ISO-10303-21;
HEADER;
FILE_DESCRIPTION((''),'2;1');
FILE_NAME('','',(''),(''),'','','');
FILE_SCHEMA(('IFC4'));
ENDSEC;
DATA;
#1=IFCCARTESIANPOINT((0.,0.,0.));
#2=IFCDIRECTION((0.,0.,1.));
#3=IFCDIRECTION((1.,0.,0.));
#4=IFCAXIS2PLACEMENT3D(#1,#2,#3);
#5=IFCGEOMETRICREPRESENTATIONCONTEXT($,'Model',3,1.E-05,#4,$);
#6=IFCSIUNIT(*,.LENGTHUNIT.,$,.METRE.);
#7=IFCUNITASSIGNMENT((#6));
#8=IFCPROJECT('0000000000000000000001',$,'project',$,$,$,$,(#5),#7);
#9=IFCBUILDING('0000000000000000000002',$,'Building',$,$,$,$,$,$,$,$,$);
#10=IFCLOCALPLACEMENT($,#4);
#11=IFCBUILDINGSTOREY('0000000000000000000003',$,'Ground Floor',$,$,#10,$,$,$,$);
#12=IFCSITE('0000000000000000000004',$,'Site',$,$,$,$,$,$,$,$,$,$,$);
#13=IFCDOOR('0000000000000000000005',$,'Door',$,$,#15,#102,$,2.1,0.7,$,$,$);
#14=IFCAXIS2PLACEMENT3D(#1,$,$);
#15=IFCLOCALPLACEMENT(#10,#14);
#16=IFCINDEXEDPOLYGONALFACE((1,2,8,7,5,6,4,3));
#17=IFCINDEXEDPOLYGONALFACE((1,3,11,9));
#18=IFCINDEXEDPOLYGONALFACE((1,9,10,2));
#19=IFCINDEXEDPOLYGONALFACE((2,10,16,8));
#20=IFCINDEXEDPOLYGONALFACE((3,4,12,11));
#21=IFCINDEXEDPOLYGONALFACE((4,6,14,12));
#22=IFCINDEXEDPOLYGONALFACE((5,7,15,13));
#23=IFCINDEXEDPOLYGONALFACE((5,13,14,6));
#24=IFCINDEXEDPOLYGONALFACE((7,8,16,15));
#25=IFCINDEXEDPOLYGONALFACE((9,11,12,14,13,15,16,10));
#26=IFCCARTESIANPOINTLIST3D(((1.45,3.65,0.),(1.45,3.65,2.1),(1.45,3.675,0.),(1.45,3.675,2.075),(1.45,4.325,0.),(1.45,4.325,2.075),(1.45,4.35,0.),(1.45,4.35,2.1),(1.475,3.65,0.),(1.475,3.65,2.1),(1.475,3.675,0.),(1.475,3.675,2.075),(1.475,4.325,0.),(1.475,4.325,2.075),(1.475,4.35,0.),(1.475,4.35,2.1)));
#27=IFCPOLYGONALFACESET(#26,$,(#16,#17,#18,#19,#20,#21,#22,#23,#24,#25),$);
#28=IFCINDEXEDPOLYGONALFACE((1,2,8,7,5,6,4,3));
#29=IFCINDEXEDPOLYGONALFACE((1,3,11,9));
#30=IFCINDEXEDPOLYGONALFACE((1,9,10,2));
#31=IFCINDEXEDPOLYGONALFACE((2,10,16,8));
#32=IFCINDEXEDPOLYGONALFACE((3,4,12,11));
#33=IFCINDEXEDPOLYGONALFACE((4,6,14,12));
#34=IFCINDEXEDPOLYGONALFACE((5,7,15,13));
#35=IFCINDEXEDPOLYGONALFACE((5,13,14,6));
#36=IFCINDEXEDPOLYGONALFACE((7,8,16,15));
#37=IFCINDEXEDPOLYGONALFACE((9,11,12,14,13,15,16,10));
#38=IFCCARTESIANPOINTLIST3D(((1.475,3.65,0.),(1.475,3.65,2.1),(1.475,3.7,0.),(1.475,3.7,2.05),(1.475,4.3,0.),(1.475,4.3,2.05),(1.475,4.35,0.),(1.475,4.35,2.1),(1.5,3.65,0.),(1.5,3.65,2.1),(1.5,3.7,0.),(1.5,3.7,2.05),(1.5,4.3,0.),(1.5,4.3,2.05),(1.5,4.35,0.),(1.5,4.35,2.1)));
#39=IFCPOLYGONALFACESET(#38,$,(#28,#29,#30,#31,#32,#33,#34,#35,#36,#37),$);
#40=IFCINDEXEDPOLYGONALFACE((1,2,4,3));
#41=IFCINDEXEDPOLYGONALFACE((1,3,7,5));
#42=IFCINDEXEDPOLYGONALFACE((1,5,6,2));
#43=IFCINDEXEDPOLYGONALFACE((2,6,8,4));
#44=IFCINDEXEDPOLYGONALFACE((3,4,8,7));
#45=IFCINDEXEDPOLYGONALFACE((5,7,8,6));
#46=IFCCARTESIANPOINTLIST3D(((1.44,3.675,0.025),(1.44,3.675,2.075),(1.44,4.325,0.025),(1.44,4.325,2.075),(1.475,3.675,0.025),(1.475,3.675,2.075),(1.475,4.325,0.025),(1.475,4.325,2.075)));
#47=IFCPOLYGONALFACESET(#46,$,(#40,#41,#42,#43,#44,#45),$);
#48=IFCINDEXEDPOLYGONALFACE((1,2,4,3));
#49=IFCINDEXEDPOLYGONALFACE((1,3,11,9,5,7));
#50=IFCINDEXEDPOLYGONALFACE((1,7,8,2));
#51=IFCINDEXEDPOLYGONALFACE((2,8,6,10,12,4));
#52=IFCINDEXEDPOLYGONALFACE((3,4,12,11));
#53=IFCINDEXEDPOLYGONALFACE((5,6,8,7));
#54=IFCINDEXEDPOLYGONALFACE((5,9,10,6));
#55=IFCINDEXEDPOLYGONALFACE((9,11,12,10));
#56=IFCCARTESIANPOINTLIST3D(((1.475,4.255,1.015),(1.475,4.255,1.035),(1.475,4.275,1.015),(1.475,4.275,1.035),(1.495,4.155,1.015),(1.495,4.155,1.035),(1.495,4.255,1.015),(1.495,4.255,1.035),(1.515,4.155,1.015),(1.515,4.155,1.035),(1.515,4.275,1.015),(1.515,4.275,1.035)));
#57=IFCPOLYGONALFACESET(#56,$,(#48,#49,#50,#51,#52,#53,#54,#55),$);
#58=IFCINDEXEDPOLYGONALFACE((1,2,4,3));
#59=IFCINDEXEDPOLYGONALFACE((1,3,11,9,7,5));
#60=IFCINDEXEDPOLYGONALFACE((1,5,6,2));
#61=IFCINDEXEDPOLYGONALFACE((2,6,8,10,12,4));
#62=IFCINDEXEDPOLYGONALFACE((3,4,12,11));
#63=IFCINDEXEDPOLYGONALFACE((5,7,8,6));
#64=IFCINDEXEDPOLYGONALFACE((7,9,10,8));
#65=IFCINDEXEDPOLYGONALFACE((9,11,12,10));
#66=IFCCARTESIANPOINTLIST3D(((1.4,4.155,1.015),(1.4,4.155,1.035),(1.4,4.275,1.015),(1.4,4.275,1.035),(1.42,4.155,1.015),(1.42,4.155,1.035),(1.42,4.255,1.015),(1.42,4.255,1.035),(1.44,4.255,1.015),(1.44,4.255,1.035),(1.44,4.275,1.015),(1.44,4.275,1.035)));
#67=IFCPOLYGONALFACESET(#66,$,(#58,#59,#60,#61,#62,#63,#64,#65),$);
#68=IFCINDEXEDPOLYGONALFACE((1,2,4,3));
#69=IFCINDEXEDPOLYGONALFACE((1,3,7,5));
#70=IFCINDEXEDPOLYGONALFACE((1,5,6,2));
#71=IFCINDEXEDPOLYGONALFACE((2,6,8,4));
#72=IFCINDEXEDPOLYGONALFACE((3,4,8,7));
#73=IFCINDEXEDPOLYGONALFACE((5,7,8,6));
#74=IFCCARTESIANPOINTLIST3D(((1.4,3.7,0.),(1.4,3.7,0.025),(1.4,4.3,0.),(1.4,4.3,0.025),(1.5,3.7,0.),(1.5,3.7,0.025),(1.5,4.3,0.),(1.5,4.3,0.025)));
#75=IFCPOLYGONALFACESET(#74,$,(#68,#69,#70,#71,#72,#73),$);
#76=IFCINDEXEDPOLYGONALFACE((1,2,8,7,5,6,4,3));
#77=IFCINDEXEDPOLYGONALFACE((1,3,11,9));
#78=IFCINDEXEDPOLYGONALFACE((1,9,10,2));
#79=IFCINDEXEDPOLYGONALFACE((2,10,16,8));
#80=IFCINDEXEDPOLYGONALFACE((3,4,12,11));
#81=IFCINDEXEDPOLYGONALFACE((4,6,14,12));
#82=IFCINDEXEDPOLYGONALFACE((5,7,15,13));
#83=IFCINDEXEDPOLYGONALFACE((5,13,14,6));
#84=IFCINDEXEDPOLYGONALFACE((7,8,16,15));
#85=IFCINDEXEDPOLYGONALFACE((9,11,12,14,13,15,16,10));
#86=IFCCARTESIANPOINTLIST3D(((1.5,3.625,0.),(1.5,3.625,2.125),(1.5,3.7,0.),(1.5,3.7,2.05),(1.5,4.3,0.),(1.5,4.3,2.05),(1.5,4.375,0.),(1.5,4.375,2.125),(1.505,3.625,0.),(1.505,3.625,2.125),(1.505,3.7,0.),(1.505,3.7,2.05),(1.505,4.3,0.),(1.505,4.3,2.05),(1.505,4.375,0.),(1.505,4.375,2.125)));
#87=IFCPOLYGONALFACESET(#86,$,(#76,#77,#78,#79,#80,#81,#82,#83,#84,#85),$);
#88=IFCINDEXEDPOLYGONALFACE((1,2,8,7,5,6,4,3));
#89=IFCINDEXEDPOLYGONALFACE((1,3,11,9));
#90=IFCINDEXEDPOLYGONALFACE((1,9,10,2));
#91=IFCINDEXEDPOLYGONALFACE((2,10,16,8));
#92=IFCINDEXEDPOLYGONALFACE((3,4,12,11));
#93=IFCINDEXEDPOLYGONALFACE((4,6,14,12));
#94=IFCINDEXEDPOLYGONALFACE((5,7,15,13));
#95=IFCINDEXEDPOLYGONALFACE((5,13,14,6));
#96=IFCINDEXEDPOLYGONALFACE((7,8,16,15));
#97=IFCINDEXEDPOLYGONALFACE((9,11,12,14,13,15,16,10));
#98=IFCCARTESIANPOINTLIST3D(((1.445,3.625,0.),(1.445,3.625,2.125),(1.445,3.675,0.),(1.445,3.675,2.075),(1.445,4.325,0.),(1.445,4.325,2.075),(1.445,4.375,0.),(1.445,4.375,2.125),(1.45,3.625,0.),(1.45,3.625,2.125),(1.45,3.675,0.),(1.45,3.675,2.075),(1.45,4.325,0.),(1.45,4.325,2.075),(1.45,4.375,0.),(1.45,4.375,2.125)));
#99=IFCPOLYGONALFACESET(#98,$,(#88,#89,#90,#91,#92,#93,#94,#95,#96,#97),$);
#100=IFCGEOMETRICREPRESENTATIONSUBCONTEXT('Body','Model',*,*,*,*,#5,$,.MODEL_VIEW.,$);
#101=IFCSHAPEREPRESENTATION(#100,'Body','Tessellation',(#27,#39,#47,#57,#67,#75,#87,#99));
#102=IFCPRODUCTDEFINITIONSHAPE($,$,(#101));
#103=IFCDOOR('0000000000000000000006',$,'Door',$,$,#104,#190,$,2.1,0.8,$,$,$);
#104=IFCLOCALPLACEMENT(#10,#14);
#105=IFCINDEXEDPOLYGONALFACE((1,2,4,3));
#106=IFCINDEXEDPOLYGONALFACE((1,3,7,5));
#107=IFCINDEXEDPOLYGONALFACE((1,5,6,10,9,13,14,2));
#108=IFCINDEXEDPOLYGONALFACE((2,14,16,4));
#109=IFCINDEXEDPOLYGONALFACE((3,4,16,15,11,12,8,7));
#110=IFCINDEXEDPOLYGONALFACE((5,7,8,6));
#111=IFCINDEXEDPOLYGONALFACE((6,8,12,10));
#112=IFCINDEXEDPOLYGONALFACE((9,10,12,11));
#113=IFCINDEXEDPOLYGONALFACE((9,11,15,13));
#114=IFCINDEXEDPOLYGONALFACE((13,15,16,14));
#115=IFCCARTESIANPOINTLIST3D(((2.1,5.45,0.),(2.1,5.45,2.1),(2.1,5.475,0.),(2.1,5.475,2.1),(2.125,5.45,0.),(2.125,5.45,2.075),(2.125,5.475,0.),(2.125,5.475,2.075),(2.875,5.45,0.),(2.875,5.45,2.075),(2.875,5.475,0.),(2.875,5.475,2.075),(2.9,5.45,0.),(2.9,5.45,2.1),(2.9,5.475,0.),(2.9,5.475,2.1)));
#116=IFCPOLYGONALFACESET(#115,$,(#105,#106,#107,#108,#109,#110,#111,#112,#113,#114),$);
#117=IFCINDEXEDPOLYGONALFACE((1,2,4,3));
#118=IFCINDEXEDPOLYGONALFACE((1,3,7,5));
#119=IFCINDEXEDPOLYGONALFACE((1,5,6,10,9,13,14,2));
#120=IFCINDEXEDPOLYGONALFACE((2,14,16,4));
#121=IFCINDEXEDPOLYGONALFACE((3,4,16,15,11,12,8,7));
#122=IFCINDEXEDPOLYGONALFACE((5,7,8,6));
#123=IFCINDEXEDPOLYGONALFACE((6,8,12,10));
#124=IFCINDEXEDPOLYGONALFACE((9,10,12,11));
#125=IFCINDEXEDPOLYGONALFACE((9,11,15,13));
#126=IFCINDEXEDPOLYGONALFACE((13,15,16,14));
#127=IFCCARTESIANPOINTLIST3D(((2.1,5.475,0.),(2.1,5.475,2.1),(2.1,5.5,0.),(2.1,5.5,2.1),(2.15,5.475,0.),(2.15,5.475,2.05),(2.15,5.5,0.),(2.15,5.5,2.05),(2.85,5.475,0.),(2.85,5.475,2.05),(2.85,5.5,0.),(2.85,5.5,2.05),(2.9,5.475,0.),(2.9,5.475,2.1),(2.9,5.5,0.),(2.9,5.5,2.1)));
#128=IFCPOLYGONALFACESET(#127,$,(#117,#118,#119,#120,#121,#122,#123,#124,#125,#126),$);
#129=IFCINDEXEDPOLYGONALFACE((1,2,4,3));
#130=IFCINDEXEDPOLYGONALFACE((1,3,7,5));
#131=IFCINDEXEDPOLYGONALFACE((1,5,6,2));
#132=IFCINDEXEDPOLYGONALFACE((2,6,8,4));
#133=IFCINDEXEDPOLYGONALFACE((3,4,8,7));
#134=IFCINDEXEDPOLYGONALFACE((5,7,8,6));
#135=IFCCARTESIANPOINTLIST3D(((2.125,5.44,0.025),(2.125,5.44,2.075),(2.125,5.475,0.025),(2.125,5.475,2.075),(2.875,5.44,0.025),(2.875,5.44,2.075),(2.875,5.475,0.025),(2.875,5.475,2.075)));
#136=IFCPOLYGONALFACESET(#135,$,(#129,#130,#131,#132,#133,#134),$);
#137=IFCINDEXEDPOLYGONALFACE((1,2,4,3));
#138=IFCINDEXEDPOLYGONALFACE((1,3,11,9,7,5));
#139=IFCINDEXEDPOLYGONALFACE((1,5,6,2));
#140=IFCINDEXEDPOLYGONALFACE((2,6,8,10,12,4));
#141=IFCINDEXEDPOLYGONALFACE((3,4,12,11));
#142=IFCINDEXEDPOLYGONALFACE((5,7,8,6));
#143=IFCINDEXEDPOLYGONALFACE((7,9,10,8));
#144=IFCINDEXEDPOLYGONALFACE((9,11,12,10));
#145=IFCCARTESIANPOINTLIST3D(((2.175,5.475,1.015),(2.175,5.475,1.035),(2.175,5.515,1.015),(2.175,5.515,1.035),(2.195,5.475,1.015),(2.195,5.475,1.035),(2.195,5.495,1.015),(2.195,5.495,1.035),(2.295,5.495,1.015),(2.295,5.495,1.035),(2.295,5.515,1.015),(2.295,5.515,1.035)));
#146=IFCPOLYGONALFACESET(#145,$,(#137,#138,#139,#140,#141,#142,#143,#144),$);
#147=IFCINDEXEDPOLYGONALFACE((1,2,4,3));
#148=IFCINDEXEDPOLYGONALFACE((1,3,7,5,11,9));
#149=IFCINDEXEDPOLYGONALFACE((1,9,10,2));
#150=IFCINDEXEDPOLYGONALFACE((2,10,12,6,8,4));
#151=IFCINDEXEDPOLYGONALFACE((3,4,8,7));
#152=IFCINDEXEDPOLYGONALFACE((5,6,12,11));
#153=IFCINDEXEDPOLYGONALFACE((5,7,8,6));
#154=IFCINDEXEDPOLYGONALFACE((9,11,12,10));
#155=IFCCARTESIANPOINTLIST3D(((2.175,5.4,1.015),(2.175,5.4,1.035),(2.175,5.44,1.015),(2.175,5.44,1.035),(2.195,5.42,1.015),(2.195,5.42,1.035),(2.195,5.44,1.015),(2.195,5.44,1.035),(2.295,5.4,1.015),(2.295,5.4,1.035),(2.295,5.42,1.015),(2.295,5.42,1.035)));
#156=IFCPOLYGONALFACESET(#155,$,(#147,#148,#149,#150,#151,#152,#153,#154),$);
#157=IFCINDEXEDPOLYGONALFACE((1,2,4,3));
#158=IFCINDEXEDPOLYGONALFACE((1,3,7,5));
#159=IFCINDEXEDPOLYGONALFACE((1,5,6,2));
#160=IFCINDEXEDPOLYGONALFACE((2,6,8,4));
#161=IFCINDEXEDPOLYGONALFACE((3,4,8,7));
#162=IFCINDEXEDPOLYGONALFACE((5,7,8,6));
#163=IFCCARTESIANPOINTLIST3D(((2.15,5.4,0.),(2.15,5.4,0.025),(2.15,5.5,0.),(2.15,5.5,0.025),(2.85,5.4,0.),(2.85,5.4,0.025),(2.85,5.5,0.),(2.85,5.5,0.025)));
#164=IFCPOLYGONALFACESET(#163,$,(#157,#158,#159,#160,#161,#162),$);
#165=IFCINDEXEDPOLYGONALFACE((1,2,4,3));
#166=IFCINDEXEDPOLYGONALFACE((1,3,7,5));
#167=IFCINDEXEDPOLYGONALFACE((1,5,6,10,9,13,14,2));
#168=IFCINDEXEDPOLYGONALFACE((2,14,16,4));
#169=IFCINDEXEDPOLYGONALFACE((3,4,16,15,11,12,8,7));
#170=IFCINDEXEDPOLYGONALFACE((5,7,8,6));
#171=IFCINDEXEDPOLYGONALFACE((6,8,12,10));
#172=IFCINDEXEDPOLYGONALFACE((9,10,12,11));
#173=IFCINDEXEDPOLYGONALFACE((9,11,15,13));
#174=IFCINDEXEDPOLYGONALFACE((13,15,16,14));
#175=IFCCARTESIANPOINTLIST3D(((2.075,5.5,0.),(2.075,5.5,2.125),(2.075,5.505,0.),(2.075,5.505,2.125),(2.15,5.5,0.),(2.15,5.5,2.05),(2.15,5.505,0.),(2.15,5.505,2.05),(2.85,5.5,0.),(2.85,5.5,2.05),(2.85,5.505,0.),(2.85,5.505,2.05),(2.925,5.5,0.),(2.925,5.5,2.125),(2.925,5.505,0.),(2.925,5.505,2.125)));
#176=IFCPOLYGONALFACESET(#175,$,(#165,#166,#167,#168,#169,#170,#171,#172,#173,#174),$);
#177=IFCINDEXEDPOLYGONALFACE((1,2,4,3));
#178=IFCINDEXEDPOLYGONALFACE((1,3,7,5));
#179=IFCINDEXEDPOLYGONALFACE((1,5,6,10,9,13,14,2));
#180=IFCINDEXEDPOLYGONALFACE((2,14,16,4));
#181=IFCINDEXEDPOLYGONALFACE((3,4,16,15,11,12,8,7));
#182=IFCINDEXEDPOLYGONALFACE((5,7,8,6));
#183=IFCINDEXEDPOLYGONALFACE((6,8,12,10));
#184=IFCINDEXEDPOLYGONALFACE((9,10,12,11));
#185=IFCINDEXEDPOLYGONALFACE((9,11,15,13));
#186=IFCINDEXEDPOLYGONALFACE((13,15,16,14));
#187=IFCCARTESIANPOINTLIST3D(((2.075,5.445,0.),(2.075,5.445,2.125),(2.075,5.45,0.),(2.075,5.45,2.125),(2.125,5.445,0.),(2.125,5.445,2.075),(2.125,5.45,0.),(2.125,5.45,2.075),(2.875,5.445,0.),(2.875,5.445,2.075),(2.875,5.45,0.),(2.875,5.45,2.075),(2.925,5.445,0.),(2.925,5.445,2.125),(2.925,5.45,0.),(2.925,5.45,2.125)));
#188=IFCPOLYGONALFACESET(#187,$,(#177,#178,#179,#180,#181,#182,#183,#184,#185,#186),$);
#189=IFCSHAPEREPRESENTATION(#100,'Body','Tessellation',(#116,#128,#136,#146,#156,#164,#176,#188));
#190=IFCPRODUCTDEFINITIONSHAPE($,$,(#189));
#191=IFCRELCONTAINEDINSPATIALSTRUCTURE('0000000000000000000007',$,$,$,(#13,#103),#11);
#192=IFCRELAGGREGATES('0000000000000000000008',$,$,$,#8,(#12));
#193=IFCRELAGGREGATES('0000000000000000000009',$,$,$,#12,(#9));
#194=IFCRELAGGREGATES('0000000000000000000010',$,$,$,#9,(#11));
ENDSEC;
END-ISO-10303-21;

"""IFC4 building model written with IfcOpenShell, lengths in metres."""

from ifc_helpers import new_model, si_unit, frame, origin_with_axes, place, context, subcontext, project, spatial, line, indexed_curve, outline, extrude, element, save


model = new_model("IFC4")

# Units and contexts
model_context = context("Model", 3, precision=1e-05, world=origin_with_axes())
body_context = subcontext(model_context, "Body", "Model", "MODEL_VIEW")
ifc_project = project(units=[si_unit("LENGTHUNIT", "METRE")], contexts=[model_context])

# Site, building, storey
site = spatial("IfcSite", under=ifc_project, Name="Site")
building = spatial("IfcBuilding", under=site, Name="Building")
storey_placement = place(None, origin_with_axes())
storey = spatial("IfcBuildingStorey", under=building, at=storey_placement, Name="Ground Floor")

# Doors
door_1_placement = place(storey_placement, frame((1.5, 3.65, 0.0), z_axis=(0.0, 0.0, 1.0), x_axis=(0.0, 1.0, 0.0)))
element("IfcDoor", 1, at=door_1_placement, inside=storey, Name="Door", OverallHeight=2.1, OverallWidth=0.7, context=body_context, shape_type="SweptSolid", body=[
    extrude(outline(indexed_curve([(0.0, 0.0), (0.0, 2.1), (0.7, 2.1), (0.7, 0.0), (0.675, 0.0), (0.675, 2.075), (0.025, 2.075), (0.025, 0.0)], segments=[line(1, 2, 3, 4, 5, 6, 7, 8, 1)])), frame((0.0, 0.025, 0.0), z_axis=(0.0, -1.0, 0.0), x_axis=(1.0, 0.0, 0.0)), (0.0, 0.0, -1.0), 0.025),
    extrude(outline(indexed_curve([(0.0, 0.0), (0.0, 2.1), (0.7, 2.1), (0.7, 0.0), (0.65, 0.0), (0.65, 2.05), (0.05, 2.05), (0.05, 0.0)], segments=[line(1, 2, 3, 4, 5, 6, 7, 8, 1)])), frame((0.0, 0.0, 0.0), z_axis=(0.0, -1.0, 0.0), x_axis=(1.0, 0.0, 0.0)), (0.0, 0.0, -1.0), 0.025),
    extrude(outline(indexed_curve([(0.0, 0.0), (0.65, 0.0), (0.65, 0.035), (0.0, 0.035)], segments=[line(1, 2, 3, 4, 1)])), frame((0.025, 0.025, 0.025), z_axis=(0.0, 0.0, 1.0), x_axis=(1.0, 0.0, 0.0)), (0.0, 0.0, 1.0), 2.05),
    extrude(outline(indexed_curve([(0.0, 0.0), (0.0, -0.04), (-0.12, -0.04), (-0.12, -0.02), (-0.02, -0.02), (-0.02, 0.0)], segments=[line(1, 2, 3, 4, 5, 6, 1)])), frame((0.625, 0.025, 1.015), z_axis=(0.0, 0.0, 1.0), x_axis=(1.0, 0.0, 0.0)), (0.0, 0.0, 1.0), 0.02),
    extrude(outline(indexed_curve([(0.0, 0.0), (0.0, 0.04), (-0.12, 0.04), (-0.12, 0.02), (-0.02, 0.02), (-0.02, 0.0)], segments=[line(1, 2, 3, 4, 5, 6, 1)])), frame((0.625, 0.06, 1.015), z_axis=(0.0, 0.0, 1.0), x_axis=(1.0, 0.0, 0.0)), (0.0, 0.0, 1.0), 0.02),
    extrude(outline(indexed_curve([(0.0, 0.0), (0.6, 0.0), (0.6, 0.1), (0.0, 0.1)], segments=[line(1, 2, 3, 4, 1)])), frame((0.05, 0.0, 0.0), z_axis=(0.0, 0.0, 1.0), x_axis=(1.0, 0.0, 0.0)), (0.0, 0.0, 1.0), 0.025),
    extrude(outline(indexed_curve([(0.0, 0.0), (0.0, 2.125), (0.75, 2.125), (0.75, 0.0), (0.675, 0.0), (0.675, 2.05), (0.075, 2.05), (0.075, 0.0)], segments=[line(1, 2, 3, 4, 5, 6, 7, 8, 1)])), frame((-0.025, -0.005, 0.0), z_axis=(0.0, -1.0, 0.0), x_axis=(1.0, 0.0, 0.0)), (0.0, 0.0, -1.0), 0.005),
    extrude(outline(indexed_curve([(0.0, 0.0), (0.0, 2.125), (0.75, 2.125), (0.75, 0.0), (0.7, 0.0), (0.7, 2.075), (0.05, 2.075), (0.05, 0.0)], segments=[line(1, 2, 3, 4, 5, 6, 7, 8, 1)])), frame((-0.025, 0.05, 0.0), z_axis=(0.0, -1.0, 0.0), x_axis=(1.0, 0.0, 0.0)), (0.0, 0.0, -1.0), 0.005),
])
door_2_placement = place(storey_placement, frame((2.9, 5.5, 0.0), z_axis=(0.0, 0.0, 1.0), x_axis=(-1.0, 0.0, 0.0)))
element("IfcDoor", 2, at=door_2_placement, inside=storey, Name="Door", OverallHeight=2.1, OverallWidth=0.8, context=body_context, shape_type="SweptSolid", body=[
    extrude(outline(indexed_curve([(0.0, 0.0), (0.0, 2.1), (0.8, 2.1), (0.8, 0.0), (0.775, 0.0), (0.775, 2.075), (0.025, 2.075), (0.025, 0.0)], segments=[line(1, 2, 3, 4, 5, 6, 7, 8, 1)])), frame((0.0, 0.025, 0.0), z_axis=(0.0, -1.0, 0.0), x_axis=(1.0, 0.0, 0.0)), (0.0, 0.0, -1.0), 0.025),
    extrude(outline(indexed_curve([(0.0, 0.0), (0.0, 2.1), (0.8, 2.1), (0.8, 0.0), (0.75, 0.0), (0.75, 2.05), (0.05, 2.05), (0.05, 0.0)], segments=[line(1, 2, 3, 4, 5, 6, 7, 8, 1)])), frame((0.0, 0.0, 0.0), z_axis=(0.0, -1.0, 0.0), x_axis=(1.0, 0.0, 0.0)), (0.0, 0.0, -1.0), 0.025),
    extrude(outline(indexed_curve([(0.0, 0.0), (0.75, 0.0), (0.75, 0.035), (0.0, 0.035)], segments=[line(1, 2, 3, 4, 1)])), frame((0.025, 0.025, 0.025), z_axis=(0.0, 0.0, 1.0), x_axis=(1.0, 0.0, 0.0)), (0.0, 0.0, 1.0), 2.05),
    extrude(outline(indexed_curve([(0.0, 0.0), (0.0, -0.04), (-0.12, -0.04), (-0.12, -0.02), (-0.02, -0.02), (-0.02, 0.0)], segments=[line(1, 2, 3, 4, 5, 6, 1)])), frame((0.725, 0.025, 1.015), z_axis=(0.0, 0.0, 1.0), x_axis=(1.0, 0.0, 0.0)), (0.0, 0.0, 1.0), 0.02),
    extrude(outline(indexed_curve([(0.0, 0.0), (0.0, 0.04), (-0.12, 0.04), (-0.12, 0.02), (-0.02, 0.02), (-0.02, 0.0)], segments=[line(1, 2, 3, 4, 5, 6, 1)])), frame((0.725, 0.06, 1.015), z_axis=(0.0, 0.0, 1.0), x_axis=(1.0, 0.0, 0.0)), (0.0, 0.0, 1.0), 0.02),
    extrude(outline(indexed_curve([(0.0, 0.0), (0.7, 0.0), (0.7, 0.1), (0.0, 0.1)], segments=[line(1, 2, 3, 4, 1)])), frame((0.05, 0.0, 0.0), z_axis=(0.0, 0.0, 1.0), x_axis=(1.0, 0.0, 0.0)), (0.0, 0.0, 1.0), 0.025),
    extrude(outline(indexed_curve([(0.0, 0.0), (0.0, 2.125), (0.85, 2.125), (0.85, 0.0), (0.775, 0.0), (0.775, 2.05), (0.075, 2.05), (0.075, 0.0)], segments=[line(1, 2, 3, 4, 5, 6, 7, 8, 1)])), frame((-0.025, -0.005, 0.0), z_axis=(0.0, -1.0, 0.0), x_axis=(1.0, 0.0, 0.0)), (0.0, 0.0, -1.0), 0.005),
    extrude(outline(indexed_curve([(0.0, 0.0), (0.0, 2.125), (0.85, 2.125), (0.85, 0.0), (0.8, 0.0), (0.8, 2.075), (0.05, 2.075), (0.05, 0.0)], segments=[line(1, 2, 3, 4, 5, 6, 7, 8, 1)])), frame((-0.025, 0.05, 0.0), z_axis=(0.0, -1.0, 0.0), x_axis=(1.0, 0.0, 0.0)), (0.0, 0.0, -1.0), 0.005),
])

save(model, "model.ifc")
